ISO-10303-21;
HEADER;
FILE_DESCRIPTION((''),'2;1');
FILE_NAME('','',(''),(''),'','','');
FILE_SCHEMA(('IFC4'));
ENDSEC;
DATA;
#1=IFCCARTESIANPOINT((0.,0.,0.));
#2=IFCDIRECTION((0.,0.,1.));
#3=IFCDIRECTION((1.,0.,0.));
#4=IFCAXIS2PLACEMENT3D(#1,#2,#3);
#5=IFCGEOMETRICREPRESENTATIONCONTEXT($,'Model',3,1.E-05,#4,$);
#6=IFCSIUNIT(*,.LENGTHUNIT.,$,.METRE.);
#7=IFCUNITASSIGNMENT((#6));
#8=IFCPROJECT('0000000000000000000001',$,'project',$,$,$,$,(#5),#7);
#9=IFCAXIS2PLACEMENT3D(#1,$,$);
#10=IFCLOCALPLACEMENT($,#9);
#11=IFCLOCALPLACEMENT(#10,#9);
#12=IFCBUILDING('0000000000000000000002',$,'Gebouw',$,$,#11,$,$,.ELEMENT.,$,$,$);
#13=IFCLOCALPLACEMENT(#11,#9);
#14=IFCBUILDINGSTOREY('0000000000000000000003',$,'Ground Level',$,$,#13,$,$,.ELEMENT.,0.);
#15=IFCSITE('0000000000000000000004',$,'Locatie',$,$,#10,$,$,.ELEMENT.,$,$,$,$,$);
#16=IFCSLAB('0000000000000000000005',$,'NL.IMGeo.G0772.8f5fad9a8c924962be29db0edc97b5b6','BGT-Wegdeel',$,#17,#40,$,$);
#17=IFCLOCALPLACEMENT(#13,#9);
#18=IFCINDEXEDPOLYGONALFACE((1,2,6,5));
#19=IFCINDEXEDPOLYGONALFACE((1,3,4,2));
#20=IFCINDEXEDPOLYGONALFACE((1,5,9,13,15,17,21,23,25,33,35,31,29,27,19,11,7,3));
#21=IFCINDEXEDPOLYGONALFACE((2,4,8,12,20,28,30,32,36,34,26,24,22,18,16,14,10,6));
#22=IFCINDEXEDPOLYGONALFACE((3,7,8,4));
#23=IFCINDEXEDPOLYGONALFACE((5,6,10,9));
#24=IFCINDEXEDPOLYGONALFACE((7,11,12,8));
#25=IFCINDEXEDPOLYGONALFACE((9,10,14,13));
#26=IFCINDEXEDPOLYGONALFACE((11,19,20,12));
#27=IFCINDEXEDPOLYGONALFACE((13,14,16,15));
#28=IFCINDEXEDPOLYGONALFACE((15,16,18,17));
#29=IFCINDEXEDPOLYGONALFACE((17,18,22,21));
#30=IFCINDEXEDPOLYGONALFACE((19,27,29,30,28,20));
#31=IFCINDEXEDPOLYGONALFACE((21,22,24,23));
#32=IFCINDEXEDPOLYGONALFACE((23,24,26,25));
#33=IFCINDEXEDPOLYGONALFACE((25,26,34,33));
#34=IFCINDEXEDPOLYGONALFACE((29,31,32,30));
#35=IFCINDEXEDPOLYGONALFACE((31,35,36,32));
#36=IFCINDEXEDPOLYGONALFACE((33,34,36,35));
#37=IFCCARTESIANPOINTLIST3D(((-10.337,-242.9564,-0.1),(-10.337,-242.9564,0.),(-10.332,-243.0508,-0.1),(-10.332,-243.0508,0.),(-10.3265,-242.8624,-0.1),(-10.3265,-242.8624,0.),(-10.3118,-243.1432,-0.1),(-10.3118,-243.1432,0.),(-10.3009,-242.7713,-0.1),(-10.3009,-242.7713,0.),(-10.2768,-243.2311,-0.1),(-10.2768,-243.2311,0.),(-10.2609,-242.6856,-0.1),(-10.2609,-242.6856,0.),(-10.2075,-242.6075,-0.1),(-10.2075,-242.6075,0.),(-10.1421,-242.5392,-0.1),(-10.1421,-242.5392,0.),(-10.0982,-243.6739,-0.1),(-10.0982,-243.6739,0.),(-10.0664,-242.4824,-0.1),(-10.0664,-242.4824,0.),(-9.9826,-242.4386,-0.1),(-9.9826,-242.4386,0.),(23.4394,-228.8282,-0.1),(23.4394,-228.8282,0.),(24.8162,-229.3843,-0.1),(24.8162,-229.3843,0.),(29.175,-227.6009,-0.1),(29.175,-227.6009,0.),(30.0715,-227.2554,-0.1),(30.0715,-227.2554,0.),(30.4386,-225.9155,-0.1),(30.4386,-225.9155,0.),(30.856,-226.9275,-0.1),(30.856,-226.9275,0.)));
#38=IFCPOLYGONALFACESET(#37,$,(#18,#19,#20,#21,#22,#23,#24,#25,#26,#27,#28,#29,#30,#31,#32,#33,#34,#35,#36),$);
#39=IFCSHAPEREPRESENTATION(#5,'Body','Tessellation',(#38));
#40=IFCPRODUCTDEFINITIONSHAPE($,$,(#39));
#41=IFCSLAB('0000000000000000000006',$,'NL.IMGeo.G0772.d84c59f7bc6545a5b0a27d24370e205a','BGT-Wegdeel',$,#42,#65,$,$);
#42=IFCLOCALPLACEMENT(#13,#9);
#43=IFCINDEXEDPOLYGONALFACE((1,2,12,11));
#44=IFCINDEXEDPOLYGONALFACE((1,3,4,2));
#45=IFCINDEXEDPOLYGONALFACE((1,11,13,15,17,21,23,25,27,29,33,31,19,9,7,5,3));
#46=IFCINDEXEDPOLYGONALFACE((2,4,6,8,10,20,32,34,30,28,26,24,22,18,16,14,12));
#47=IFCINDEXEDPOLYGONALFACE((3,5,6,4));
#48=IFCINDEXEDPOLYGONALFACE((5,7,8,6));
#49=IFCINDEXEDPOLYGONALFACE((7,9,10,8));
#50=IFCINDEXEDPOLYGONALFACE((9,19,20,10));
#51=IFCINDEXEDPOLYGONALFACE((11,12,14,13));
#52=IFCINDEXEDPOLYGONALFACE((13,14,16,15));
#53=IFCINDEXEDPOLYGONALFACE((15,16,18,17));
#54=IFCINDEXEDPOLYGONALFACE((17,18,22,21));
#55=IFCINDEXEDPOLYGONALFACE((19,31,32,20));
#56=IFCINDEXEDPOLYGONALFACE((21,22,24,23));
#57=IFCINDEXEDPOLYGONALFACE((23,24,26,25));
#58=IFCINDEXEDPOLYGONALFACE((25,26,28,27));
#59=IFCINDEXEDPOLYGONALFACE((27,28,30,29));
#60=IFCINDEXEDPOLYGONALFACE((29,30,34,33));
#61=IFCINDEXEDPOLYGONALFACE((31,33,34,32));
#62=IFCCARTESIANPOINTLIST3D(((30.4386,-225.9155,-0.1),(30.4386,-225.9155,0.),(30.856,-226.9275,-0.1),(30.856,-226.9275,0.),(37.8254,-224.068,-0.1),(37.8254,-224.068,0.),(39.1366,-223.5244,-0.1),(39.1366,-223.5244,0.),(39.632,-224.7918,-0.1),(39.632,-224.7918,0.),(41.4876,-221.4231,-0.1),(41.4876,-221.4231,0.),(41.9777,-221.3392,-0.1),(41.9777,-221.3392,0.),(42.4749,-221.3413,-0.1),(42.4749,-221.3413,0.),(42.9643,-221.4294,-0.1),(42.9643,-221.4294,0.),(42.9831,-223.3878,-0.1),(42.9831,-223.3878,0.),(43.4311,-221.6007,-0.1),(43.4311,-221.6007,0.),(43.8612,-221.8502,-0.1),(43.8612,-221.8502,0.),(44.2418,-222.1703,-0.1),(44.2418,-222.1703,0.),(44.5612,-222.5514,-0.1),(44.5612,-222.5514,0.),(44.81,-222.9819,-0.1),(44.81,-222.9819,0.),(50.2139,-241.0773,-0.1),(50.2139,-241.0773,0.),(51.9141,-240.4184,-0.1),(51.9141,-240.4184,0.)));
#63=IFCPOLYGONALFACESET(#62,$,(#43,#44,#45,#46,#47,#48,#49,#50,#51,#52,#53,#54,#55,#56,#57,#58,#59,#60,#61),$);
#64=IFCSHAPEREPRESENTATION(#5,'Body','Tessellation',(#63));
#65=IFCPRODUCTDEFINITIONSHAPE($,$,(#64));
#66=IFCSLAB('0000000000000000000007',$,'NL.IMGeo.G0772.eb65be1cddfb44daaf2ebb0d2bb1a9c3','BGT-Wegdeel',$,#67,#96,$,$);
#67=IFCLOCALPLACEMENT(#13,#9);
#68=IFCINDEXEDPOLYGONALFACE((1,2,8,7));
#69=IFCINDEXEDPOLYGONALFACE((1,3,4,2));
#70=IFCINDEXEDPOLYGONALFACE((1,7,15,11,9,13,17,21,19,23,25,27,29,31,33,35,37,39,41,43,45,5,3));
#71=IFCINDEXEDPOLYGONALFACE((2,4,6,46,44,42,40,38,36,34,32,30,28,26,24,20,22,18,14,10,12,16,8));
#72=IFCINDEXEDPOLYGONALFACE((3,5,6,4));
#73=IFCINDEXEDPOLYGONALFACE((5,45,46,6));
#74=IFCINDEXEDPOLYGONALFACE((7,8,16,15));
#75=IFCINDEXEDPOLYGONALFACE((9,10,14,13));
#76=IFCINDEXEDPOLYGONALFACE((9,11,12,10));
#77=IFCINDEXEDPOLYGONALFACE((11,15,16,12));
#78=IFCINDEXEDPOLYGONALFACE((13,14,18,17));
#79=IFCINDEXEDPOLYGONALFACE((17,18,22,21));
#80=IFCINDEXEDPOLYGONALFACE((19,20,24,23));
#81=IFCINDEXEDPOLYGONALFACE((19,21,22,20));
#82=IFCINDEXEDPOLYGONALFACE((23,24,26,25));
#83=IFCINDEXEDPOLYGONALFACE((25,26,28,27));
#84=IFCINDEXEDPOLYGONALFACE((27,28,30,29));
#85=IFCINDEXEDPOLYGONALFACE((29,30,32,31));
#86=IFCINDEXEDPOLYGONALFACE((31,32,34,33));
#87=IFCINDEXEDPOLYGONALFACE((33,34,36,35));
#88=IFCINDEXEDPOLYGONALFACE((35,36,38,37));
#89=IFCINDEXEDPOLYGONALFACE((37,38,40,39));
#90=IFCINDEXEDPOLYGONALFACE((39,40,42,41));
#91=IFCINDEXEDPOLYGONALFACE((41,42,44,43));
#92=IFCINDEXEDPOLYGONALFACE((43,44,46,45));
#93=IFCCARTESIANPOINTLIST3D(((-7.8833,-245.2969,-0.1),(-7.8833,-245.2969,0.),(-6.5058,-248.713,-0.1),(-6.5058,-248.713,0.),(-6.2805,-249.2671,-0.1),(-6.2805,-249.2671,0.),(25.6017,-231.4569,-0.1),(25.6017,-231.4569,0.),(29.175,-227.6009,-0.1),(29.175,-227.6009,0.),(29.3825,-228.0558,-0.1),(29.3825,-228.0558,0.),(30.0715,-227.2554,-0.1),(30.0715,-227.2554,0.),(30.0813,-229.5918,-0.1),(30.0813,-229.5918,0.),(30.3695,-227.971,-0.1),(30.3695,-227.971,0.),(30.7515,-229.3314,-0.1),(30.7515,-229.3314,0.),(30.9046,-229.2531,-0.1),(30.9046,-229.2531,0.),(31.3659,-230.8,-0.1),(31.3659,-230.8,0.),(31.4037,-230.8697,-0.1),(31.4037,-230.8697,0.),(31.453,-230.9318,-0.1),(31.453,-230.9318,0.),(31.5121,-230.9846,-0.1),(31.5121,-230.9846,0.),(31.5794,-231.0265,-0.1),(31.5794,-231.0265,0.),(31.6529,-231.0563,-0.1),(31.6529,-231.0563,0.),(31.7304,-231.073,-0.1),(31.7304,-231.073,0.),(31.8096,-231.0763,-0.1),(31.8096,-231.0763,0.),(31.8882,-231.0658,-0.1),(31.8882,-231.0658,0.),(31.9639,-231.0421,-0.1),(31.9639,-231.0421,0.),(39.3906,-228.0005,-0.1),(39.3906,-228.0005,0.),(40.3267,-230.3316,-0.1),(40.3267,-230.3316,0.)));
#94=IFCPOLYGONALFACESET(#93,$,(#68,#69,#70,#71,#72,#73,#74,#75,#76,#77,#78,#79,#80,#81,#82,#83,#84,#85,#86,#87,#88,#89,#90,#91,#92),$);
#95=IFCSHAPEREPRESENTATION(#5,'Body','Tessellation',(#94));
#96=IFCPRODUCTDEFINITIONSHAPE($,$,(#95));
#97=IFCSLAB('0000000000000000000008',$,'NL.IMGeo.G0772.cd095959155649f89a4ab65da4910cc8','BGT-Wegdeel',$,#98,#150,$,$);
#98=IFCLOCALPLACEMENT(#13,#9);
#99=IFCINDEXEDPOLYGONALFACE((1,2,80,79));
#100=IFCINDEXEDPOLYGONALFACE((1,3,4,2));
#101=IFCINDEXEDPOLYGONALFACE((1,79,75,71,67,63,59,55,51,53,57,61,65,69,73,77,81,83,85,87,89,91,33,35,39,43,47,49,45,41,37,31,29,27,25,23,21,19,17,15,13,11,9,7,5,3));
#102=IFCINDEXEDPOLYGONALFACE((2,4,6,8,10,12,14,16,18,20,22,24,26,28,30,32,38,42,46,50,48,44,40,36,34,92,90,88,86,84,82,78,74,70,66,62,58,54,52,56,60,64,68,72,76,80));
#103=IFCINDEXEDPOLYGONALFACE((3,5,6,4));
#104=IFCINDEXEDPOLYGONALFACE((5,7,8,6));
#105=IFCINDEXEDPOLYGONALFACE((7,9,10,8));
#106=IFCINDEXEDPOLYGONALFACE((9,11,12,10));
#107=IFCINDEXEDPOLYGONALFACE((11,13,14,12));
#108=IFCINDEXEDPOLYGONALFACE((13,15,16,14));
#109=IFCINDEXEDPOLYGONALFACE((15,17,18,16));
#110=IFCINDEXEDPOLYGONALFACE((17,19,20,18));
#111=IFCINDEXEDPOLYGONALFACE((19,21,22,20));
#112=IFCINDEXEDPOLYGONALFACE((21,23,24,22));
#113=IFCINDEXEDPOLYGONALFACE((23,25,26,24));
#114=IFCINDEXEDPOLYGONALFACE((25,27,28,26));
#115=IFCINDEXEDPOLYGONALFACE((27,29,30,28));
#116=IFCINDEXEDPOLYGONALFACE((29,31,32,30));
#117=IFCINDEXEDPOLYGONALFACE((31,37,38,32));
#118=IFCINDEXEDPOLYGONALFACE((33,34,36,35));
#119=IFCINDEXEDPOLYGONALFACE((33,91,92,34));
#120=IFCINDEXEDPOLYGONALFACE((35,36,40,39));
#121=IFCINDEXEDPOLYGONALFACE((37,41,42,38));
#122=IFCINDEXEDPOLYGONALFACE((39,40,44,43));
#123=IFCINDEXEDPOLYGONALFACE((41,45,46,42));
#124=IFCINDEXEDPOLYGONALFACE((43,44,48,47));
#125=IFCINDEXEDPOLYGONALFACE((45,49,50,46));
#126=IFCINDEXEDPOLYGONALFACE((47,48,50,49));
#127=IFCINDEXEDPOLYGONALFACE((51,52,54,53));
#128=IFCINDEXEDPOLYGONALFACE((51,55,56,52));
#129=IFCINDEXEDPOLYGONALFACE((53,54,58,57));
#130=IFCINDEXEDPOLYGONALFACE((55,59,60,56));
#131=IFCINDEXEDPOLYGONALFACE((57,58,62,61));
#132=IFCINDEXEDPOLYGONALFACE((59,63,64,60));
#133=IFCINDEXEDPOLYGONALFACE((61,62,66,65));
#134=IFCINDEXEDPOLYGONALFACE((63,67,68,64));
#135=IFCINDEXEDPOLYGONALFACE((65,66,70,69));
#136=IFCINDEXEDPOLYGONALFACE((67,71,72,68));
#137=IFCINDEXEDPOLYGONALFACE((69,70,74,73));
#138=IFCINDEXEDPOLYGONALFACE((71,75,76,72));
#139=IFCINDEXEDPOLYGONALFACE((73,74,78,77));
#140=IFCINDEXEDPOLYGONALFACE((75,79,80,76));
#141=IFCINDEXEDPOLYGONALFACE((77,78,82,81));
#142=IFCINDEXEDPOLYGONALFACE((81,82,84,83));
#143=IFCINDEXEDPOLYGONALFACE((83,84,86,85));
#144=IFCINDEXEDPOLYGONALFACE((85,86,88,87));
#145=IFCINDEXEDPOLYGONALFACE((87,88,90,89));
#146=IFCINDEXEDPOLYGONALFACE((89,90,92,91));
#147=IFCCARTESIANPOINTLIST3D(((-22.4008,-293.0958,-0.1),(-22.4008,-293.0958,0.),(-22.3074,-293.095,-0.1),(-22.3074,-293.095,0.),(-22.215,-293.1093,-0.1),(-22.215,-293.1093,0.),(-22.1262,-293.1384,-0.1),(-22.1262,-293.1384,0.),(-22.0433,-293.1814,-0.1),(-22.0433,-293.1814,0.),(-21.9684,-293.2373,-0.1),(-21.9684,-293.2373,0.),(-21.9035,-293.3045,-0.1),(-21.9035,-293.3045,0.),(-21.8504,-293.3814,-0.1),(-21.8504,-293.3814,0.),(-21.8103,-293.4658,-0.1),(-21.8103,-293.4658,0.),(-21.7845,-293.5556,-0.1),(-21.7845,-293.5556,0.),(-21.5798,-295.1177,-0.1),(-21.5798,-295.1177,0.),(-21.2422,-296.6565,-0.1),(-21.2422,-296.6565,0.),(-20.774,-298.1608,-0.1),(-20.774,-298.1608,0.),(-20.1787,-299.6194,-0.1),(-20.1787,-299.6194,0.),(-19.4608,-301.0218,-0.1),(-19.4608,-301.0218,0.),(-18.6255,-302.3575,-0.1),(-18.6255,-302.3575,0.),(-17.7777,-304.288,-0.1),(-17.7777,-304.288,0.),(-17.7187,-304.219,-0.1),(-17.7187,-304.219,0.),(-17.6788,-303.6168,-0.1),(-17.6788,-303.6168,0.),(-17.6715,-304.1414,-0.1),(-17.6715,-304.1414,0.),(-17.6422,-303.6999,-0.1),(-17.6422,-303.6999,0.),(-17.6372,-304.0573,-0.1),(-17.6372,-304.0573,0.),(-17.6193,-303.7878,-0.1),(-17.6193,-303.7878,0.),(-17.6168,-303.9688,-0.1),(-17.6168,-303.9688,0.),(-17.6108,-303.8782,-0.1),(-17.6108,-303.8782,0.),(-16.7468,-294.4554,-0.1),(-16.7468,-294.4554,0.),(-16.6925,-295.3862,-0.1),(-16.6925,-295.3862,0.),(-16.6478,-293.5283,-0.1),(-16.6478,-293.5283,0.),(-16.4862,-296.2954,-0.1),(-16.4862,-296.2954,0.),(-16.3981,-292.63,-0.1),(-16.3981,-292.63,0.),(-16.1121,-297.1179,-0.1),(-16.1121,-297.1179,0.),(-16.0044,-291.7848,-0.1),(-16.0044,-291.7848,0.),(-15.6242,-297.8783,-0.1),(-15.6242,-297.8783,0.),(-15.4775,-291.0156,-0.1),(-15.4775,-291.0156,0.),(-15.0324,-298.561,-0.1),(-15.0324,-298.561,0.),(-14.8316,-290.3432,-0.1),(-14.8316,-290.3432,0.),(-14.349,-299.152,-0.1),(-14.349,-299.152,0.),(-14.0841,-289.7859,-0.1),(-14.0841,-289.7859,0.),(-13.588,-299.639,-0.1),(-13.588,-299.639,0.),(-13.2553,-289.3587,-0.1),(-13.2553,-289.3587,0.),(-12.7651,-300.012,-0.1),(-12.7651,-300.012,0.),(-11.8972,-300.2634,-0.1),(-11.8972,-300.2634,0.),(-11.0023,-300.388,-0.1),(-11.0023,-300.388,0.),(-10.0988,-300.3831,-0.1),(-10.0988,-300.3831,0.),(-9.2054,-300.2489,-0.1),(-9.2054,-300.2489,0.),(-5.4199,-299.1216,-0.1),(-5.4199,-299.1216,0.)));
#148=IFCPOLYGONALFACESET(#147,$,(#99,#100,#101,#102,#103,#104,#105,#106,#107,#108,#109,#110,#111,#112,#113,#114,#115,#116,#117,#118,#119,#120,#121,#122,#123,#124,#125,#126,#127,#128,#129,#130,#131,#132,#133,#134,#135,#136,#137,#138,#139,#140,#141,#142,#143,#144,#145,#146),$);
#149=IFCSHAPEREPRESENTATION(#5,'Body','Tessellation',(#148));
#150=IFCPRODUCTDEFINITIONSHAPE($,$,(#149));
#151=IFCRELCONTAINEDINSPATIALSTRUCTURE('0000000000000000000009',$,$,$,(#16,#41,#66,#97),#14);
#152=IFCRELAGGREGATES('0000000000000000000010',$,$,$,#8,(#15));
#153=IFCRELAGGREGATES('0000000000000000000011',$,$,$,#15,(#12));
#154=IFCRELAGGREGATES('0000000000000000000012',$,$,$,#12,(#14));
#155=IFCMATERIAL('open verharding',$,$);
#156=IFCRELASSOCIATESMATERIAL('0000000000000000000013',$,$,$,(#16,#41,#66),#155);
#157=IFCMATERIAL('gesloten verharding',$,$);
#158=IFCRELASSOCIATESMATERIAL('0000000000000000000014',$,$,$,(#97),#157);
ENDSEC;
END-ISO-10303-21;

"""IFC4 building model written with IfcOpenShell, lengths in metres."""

from ifc_helpers import new_model, si_unit, frame, origin, origin_with_axes, place, context, project, spatial, polyline, outline, extrude, material, element, save


model = new_model("IFC4")

# Units and contexts
model_context = context("Model", 3, precision=1e-05, world=origin_with_axes())
ifc_project = project(units=[si_unit("LENGTHUNIT", "METRE")], contexts=[model_context])

# Site, building, storey
site_placement = place(None, origin())
site = spatial("IfcSite", under=ifc_project, at=site_placement, Name="Locatie", CompositionType="ELEMENT")
building_placement = place(site_placement, origin())
building = spatial("IfcBuilding", under=site, at=building_placement, Name="Gebouw", CompositionType="ELEMENT")
storey_placement = place(building_placement, origin())
storey = spatial("IfcBuildingStorey", under=building, at=storey_placement, Name="Ground Level", CompositionType="ELEMENT", Elevation=0.0)

# Slabs
ifc_material_1 = material(Name="open verharding")
ifc_material_2 = material(Name="gesloten verharding")
slab_1_placement = place(storey_placement, origin())
element("IfcSlab", 1, at=slab_1_placement, inside=storey, material=ifc_material_1, Name="NL.IMGeo.G0772.8f5fad9a8c924962be29db0edc97b5b6", Description="BGT-Wegdeel", context=model_context, shape_type="SweptSolid", body=[
    extrude(outline(polyline([(23.4394, -228.8282), (30.4386, -225.9155), (30.856, -226.9275), (30.0715, -227.2554), (29.175, -227.6009), (24.8162, -229.3843), (-10.0982, -243.6739), (-10.2768, -243.2311), (-10.3118, -243.1432), (-10.332, -243.0508), (-10.337, -242.9564), (-10.3265, -242.8624), (-10.3009, -242.7713), (-10.2609, -242.6856), (-10.2075, -242.6075), (-10.1421, -242.5392), (-10.0664, -242.4824), (-9.9826, -242.4386), (23.4394, -228.8282)])), frame((0.0, 0.0, -0.1), z_axis=(0.0, 0.0, 1.0), x_axis=(1.0, 0.0, 0.0)), (0.0, 0.0, 1.0), 0.1),
])
slab_2_placement = place(storey_placement, origin())
element("IfcSlab", 2, at=slab_2_placement, inside=storey, material=ifc_material_1, Name="NL.IMGeo.G0772.d84c59f7bc6545a5b0a27d24370e205a", Description="BGT-Wegdeel", context=model_context, shape_type="SweptSolid", body=[
    extrude(outline(polyline([(51.9141, -240.4184), (50.2139, -241.0773), (42.9831, -223.3878), (39.632, -224.7918), (39.1366, -223.5244), (37.8254, -224.068), (30.856, -226.9275), (30.4386, -225.9155), (41.4876, -221.4231), (41.9777, -221.3392), (42.4749, -221.3413), (42.9643, -221.4294), (43.4311, -221.6007), (43.8612, -221.8502), (44.2418, -222.1703), (44.5612, -222.5514), (44.81, -222.9819), (51.9141, -240.4184)])), frame((0.0, 0.0, -0.1), z_axis=(0.0, 0.0, 1.0), x_axis=(1.0, 0.0, 0.0)), (0.0, 0.0, 1.0), 0.1),
])
slab_3_placement = place(storey_placement, origin())
element("IfcSlab", 3, at=slab_3_placement, inside=storey, material=ifc_material_1, Name="NL.IMGeo.G0772.eb65be1cddfb44daaf2ebb0d2bb1a9c3", Description="BGT-Wegdeel", context=model_context, shape_type="SweptSolid", body=[
    extrude(outline(polyline([(25.6017, -231.4569), (30.0813, -229.5918), (29.3825, -228.0558), (29.175, -227.6009), (30.0715, -227.2554), (30.3695, -227.971), (30.9046, -229.2531), (30.7515, -229.3314), (31.3659, -230.8), (31.4037, -230.8697), (31.453, -230.9318), (31.5121, -230.9846), (31.5794, -231.0265), (31.6529, -231.0563), (31.7304, -231.073), (31.8096, -231.0763), (31.8882, -231.0658), (31.9639, -231.0421), (39.3906, -228.0005), (40.3267, -230.3316), (-6.2805, -249.2671), (-6.5058, -248.713), (-7.8833, -245.2969), (25.6017, -231.4569)])), frame((0.0, 0.0, -0.1), z_axis=(0.0, 0.0, 1.0), x_axis=(1.0, 0.0, 0.0)), (0.0, 0.0, 1.0), 0.1),
])
slab_4_placement = place(storey_placement, origin())
element("IfcSlab", 4, at=slab_4_placement, inside=storey, material=ifc_material_2, Name="NL.IMGeo.G0772.cd095959155649f89a4ab65da4910cc8", Description="BGT-Wegdeel", context=model_context, shape_type="SweptSolid", body=[
    extrude(outline(polyline([(-14.0841, -289.7859), (-14.8316, -290.3432), (-15.4775, -291.0156), (-16.0044, -291.7848), (-16.3981, -292.63), (-16.6478, -293.5283), (-16.7468, -294.4554), (-16.6925, -295.3862), (-16.4862, -296.2954), (-16.1121, -297.1179), (-15.6242, -297.8783), (-15.0324, -298.561), (-14.349, -299.152), (-13.588, -299.639), (-12.7651, -300.012), (-11.8972, -300.2634), (-11.0023, -300.388), (-10.0988, -300.3831), (-9.2054, -300.2489), (-5.4199, -299.1216), (-17.7777, -304.288), (-17.7187, -304.219), (-17.6715, -304.1414), (-17.6372, -304.0573), (-17.6168, -303.9688), (-17.6108, -303.8782), (-17.6193, -303.7878), (-17.6422, -303.6999), (-17.6788, -303.6168), (-18.6255, -302.3575), (-19.4608, -301.0218), (-20.1787, -299.6194), (-20.774, -298.1608), (-21.2422, -296.6565), (-21.5798, -295.1177), (-21.7845, -293.5556), (-21.8103, -293.4658), (-21.8504, -293.3814), (-21.9035, -293.3045), (-21.9684, -293.2373), (-22.0433, -293.1814), (-22.1262, -293.1384), (-22.215, -293.1093), (-22.3074, -293.095), (-22.4008, -293.0958), (-13.2553, -289.3587), (-14.0841, -289.7859)])), frame((0.0, 0.0, -0.1), z_axis=(0.0, 0.0, 1.0), x_axis=(1.0, 0.0, 0.0)), (0.0, 0.0, 1.0), 0.1),
])

save(model, "model.ifc")
